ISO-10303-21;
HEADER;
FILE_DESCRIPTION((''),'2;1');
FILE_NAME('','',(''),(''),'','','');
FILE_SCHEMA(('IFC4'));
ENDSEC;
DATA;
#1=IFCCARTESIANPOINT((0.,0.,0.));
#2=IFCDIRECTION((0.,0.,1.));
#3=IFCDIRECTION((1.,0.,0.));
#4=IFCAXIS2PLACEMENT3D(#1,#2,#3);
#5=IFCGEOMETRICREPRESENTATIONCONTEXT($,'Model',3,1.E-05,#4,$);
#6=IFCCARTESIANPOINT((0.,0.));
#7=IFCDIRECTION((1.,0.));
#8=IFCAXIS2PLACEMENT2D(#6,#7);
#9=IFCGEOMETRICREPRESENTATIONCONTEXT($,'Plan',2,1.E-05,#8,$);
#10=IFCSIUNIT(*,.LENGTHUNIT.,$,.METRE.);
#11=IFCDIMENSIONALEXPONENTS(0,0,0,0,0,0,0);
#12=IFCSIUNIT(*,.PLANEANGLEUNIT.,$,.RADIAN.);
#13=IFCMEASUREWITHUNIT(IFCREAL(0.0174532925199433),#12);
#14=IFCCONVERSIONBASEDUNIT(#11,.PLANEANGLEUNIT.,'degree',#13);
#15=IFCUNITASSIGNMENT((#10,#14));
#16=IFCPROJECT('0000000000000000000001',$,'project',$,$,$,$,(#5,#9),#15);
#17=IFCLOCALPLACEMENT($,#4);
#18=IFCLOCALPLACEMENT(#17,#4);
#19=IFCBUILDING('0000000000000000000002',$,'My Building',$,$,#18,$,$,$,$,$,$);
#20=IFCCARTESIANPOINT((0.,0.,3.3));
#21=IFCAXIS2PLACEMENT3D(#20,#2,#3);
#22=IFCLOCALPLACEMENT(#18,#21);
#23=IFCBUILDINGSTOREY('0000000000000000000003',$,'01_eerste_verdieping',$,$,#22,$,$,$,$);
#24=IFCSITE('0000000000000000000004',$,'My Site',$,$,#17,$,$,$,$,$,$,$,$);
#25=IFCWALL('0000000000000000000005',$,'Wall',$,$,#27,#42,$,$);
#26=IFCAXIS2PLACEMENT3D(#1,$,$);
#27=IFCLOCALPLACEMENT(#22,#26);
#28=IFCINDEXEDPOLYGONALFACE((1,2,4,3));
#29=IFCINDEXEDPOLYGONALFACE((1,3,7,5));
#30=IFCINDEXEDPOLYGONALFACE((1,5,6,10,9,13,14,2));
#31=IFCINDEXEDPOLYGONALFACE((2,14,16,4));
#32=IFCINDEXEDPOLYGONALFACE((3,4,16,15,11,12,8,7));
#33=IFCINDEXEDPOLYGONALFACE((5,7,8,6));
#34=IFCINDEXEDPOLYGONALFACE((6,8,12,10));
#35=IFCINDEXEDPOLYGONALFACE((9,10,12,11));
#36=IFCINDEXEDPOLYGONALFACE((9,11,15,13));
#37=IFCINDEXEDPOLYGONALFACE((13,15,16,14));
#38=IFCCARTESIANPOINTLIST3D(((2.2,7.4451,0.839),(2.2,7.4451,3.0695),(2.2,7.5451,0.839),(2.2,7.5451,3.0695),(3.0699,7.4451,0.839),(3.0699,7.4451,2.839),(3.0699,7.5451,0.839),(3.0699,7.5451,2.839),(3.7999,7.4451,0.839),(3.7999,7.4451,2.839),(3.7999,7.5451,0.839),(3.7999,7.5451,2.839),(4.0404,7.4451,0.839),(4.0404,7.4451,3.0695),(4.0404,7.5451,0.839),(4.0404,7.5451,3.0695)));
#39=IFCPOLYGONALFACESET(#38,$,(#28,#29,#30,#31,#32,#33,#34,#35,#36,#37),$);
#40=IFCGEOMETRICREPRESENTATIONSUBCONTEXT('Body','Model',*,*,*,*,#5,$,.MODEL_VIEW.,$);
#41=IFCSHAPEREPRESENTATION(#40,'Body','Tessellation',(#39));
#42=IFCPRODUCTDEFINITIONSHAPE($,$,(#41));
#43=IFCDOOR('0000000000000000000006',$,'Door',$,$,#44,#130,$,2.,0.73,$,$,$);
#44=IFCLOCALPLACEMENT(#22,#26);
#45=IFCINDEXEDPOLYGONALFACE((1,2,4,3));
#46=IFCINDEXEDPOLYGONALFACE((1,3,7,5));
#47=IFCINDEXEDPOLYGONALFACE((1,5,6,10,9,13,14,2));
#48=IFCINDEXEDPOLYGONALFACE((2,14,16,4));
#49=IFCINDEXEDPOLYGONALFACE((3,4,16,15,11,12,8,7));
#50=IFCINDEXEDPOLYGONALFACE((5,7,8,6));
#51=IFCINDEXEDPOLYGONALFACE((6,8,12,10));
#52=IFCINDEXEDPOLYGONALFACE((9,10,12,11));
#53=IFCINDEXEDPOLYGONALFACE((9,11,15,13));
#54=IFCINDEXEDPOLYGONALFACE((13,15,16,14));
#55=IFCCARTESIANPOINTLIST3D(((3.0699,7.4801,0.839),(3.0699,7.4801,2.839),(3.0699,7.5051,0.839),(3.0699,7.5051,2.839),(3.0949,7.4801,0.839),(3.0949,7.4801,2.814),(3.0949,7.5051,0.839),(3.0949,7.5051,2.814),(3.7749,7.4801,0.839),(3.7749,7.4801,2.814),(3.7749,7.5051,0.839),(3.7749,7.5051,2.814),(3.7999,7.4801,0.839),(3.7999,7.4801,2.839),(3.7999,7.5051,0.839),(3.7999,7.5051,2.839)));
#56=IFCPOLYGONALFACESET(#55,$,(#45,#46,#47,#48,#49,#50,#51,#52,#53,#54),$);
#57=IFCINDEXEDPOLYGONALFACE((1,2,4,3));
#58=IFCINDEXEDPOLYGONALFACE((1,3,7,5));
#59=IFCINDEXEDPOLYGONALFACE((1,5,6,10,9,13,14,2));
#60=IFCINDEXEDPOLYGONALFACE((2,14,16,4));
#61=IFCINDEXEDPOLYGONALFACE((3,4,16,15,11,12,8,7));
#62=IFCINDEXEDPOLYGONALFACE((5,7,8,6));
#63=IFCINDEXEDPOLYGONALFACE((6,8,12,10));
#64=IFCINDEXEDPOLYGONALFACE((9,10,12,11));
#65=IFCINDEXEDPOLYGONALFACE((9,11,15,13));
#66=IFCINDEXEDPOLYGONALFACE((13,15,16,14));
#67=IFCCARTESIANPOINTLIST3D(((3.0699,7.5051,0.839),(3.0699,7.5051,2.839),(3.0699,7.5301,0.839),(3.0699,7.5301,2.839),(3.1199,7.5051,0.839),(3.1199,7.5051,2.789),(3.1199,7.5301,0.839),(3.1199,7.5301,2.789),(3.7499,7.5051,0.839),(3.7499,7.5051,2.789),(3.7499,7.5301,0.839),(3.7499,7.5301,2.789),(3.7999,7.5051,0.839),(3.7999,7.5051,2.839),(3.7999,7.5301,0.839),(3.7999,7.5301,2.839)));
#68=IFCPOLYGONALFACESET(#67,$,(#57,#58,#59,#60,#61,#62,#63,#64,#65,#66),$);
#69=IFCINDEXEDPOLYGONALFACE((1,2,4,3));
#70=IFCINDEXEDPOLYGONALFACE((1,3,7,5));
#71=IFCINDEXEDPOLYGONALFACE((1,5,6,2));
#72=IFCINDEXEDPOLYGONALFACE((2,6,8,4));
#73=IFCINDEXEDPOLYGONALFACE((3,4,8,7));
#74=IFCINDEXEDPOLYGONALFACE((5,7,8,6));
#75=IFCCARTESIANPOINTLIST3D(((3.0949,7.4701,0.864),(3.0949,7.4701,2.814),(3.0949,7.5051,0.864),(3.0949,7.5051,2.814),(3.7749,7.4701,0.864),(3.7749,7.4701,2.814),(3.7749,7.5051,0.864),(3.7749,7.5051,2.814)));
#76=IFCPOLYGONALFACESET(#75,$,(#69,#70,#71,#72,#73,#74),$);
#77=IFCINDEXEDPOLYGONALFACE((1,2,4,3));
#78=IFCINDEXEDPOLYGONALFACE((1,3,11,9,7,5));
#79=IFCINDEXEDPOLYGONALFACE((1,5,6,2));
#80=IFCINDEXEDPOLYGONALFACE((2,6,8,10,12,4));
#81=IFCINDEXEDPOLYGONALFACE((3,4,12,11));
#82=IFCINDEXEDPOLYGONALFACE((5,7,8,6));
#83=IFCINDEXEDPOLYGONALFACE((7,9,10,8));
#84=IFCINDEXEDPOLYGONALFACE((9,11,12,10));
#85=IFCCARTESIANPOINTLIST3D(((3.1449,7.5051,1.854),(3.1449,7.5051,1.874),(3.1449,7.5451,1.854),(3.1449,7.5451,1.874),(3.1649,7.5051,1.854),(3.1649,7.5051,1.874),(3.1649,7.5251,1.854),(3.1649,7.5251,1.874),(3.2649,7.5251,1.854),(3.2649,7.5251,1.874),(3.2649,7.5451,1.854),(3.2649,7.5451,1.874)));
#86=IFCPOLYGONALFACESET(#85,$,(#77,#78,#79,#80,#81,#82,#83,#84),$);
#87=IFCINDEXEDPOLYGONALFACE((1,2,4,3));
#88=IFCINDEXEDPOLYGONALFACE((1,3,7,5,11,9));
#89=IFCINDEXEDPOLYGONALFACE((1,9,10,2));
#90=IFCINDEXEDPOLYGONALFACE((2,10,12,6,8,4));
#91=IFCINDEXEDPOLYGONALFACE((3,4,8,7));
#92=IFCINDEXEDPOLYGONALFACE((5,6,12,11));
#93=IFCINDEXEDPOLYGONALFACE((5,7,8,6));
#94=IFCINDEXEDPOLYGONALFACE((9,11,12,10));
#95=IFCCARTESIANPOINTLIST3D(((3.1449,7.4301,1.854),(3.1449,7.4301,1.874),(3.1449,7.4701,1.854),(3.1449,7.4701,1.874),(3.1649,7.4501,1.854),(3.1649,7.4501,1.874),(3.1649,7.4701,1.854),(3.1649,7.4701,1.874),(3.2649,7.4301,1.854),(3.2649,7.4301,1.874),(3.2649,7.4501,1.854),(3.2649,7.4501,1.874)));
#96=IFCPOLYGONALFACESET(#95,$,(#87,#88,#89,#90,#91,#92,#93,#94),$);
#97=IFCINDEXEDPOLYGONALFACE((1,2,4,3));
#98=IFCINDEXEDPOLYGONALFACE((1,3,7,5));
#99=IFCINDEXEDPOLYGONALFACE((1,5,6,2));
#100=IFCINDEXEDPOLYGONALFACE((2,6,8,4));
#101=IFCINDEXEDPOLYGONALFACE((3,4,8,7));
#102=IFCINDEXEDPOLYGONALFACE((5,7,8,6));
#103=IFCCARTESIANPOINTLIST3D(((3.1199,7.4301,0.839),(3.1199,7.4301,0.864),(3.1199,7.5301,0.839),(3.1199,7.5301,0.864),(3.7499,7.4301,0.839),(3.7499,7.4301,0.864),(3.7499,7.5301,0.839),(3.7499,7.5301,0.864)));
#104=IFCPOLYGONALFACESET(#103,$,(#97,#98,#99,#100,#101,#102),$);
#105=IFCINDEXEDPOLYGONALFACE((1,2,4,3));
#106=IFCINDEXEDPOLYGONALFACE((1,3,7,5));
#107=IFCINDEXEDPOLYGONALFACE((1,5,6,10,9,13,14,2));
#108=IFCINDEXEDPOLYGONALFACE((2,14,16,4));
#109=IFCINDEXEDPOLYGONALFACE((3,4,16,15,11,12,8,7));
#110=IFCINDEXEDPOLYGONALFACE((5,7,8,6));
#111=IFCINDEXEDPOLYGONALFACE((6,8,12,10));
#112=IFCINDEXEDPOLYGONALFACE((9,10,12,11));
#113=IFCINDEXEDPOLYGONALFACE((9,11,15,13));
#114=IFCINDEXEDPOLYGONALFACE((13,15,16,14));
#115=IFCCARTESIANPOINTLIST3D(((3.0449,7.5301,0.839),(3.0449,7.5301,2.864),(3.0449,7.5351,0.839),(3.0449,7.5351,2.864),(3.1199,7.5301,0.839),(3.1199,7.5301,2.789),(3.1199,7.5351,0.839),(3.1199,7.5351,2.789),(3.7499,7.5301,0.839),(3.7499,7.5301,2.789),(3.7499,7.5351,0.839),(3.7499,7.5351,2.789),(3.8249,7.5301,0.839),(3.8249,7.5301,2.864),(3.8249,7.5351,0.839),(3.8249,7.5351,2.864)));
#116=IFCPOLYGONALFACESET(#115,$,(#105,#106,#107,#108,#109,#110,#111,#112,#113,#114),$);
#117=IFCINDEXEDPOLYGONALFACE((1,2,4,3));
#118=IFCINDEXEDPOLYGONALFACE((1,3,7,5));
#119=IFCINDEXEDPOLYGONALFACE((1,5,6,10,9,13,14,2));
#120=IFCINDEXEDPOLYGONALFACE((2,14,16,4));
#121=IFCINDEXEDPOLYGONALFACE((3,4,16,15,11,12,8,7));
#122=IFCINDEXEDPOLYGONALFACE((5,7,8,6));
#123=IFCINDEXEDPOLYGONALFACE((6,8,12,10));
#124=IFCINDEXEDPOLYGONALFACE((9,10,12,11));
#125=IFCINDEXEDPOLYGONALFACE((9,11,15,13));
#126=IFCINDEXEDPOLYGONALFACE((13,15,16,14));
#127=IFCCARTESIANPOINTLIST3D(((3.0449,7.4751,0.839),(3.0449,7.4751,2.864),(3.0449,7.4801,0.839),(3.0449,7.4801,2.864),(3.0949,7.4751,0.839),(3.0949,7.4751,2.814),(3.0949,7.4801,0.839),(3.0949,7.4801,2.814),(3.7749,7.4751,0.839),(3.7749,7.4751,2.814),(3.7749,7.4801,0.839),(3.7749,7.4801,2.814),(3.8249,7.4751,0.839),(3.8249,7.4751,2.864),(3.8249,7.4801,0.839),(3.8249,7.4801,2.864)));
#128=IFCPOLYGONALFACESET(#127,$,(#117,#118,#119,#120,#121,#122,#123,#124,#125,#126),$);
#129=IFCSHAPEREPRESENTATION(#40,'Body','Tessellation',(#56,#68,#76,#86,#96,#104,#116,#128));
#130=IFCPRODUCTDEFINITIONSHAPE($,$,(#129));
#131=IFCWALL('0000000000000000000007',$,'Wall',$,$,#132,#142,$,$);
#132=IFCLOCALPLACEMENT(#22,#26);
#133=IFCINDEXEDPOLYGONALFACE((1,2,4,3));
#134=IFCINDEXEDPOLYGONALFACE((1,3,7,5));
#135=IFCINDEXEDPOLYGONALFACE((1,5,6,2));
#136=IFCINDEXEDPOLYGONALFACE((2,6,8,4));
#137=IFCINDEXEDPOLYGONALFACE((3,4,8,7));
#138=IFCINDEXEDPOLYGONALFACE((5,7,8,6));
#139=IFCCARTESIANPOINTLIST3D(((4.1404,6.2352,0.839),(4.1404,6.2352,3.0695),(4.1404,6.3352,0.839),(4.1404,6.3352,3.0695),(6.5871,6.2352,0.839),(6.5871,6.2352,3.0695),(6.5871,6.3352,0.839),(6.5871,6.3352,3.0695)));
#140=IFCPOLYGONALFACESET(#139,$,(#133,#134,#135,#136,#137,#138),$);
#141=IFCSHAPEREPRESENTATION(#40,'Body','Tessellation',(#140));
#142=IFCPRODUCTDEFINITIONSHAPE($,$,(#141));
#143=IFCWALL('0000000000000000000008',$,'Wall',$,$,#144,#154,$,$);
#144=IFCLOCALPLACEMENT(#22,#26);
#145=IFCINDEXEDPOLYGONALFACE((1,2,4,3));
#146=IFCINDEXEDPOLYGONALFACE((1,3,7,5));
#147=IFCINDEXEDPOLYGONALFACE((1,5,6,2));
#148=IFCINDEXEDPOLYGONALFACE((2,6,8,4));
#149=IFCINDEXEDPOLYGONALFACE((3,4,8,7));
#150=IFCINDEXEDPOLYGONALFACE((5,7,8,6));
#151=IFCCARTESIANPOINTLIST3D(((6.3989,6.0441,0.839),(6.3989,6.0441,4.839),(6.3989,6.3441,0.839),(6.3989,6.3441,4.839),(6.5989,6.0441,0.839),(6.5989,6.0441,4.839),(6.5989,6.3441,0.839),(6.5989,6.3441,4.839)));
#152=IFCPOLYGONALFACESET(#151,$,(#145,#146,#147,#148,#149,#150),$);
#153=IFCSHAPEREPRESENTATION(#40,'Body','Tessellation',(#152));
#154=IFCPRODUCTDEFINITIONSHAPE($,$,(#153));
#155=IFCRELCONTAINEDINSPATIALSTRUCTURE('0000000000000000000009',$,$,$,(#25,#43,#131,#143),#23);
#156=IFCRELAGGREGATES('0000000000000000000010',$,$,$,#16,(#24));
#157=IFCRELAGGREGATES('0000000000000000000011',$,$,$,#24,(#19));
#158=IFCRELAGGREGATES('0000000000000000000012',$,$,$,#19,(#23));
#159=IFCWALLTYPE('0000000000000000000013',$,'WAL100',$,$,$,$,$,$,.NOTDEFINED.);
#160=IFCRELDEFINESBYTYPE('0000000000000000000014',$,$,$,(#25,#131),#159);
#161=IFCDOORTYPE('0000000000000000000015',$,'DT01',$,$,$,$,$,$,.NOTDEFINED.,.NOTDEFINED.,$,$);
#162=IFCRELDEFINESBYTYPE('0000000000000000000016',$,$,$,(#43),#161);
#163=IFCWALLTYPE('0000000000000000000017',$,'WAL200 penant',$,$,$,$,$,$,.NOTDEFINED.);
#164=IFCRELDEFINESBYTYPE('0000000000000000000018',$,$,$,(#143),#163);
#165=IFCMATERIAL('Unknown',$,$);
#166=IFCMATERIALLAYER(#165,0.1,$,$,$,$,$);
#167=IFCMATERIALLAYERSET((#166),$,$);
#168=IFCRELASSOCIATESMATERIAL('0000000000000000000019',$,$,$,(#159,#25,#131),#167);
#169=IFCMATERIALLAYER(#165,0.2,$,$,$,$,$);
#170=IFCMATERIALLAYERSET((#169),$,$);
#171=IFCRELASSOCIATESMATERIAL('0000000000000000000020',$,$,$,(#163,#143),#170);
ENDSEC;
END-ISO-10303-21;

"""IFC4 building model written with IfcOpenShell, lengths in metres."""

from ifc_helpers import new_model, entity, si_unit, converted_unit, frame, origin_with_axes, origin_2d_with_axis, place, context, subcontext, project, spatial, line, indexed_curve, outline, extrude, clip, halfspace, shape, source, transform, mapped, material, layer, layer_set, layer_usage, type_object, type_shapes, element, fill, save


model = new_model("IFC4")

# Units and contexts
model_context = context("Model", 3, precision=1e-05, world=origin_with_axes())
plan_context = context("Plan", 2, precision=1e-05, world=origin_2d_with_axis())
body_context_1 = subcontext(model_context, "Body", "Model", "MODEL_VIEW")
body_context_2 = subcontext(plan_context, "Body", "Plan", "PLAN_VIEW")
ifc_project = project(units=[si_unit("LENGTHUNIT", "METRE"), converted_unit("PLANEANGLEUNIT", "degree", entity("IfcReal", 0.0174532925199433), si_unit("PLANEANGLEUNIT", "RADIAN"), dimensions=[0, 0, 0, 0, 0, 0, 0])], contexts=[model_context, plan_context])

# Site, building, storey
site_placement = place(None, origin_with_axes())
site = spatial("IfcSite", under=ifc_project, at=site_placement, Name="My Site")
building_placement = place(site_placement, origin_with_axes())
building = spatial("IfcBuilding", under=site, at=building_placement, Name="My Building")
storey_placement = place(building_placement, frame((0.0, 0.0, 3.3), z_axis=(0.0, 0.0, 1.0), x_axis=(1.0, 0.0, 0.0)))
storey = spatial("IfcBuildingStorey", under=building, at=storey_placement, Name="01_eerste_verdieping")

# Shared definitions
ifc_material_1 = material(Name="Unknown")

# Shared definitions
ifc_layer_1 = layer(ifc_material_1, 0.1)
ifc_layer_set_1 = layer_set([ifc_layer_1])
wall_type_1 = type_object("IfcWallType", Name="WAL100", PredefinedType="NOTDEFINED", material=ifc_layer_set_1)

# Wall, opening, door
ifc_layer_usage_1 = layer_usage(ifc_layer_set_1, "AXIS2", "POSITIVE", 0.0)
wall_1_placement = place(storey_placement, frame((2.2, 7.4451, 0.839), z_axis=(0.0, 0.0, 1.0), x_axis=(1.0, -0.000001, 0.0)))
wall_1 = element("IfcWall", 1, at=wall_1_placement, inside=storey, type_object=wall_type_1, material=ifc_layer_usage_1, Name="Wall", context=body_context_1, shape_type="Clipping", body=[
    clip(extrude(outline(indexed_curve([(0.0, 0.0), (0.0, 0.1), (1.8404, 0.1), (1.8404, 0.0), (0.0, 0.0)], self_intersect=False)), origin_with_axes(), (0.0, 0.0, 1.0), 6.3695), halfspace(frame((0.0, 0.0, 2.2305), z_axis=(0.0, 0.0, 1.0), x_axis=(-1.0, 0.0, 0.0)), False)),
])
shared_shape_1 = source(origin_with_axes(), body_context_1, "Body", "SweptSolid", [
    extrude(outline(indexed_curve([(0.0, 0.0), (0.73, 0.0), (0.73, 2.0), (0.0, 2.0)], segments=[line(1, 2, 3, 4, 1)])), frame((0.0, -0.1, 0.0), z_axis=(0.0, -1.0, 0.0), x_axis=(1.0, 0.0, 0.0)), (0.0, 0.0, -1.0), 0.3),
])
opening_placement = place(wall_1_placement, frame((0.8699, 0.0, 0.0), z_axis=(0.0, 0.0, 1.0), x_axis=(1.0, 0.000001, 0.0)))
opening = element("IfcOpeningElement", 2, at=opening_placement, cuts=wall_1, PredefinedType="OPENING", context=body_context_1, shape_type="MappedRepresentation", body=[
    mapped(shared_shape_1, transform((0.0, 0.0, 0.0), x_axis=(1.0, 0.0, 0.0), y_axis=(0.0, 1.0, 0.0), z_axis=(0.0, 0.0, 1.0), scale=1.0)),
])
door_type = type_object("IfcDoorType", Name="DT01", OperationType="NOTDEFINED", PredefinedType="NOTDEFINED")
shared_shape_2 = source(origin_with_axes(), body_context_1, "Body", "SweptSolid", [
    extrude(outline(indexed_curve([(0.025, 0.0), (0.025, 1.975), (0.705, 1.975), (0.705, 0.0), (0.73, 0.0), (0.73, 2.0), (0.0, 2.0), (0.0, 0.0)], segments=[line(3, 2), line(2, 1), line(1, 8), line(8, 7), line(7, 6), line(6, 5), line(5, 4), line(4, 3)], self_intersect=False)), frame((0.0, 0.025, 0.0), z_axis=(0.0, -1.0, 0.0), x_axis=(1.0, 0.0, 0.0)), (0.0, 0.0, -1.0), 0.025),
    extrude(outline(indexed_curve([(0.0, 0.0), (0.0, 2.0), (0.73, 2.0), (0.73, 0.0), (0.68, 0.0), (0.68, 1.95), (0.05, 1.95), (0.05, 0.0)], segments=[line(1, 2, 3, 4, 5, 6, 7, 8, 1)])), frame((0.0, 0.0, 0.0), z_axis=(0.0, -1.0, 0.0), x_axis=(1.0, 0.0, 0.0)), (0.0, 0.0, -1.0), 0.025),
    extrude(outline(indexed_curve([(0.0, 0.0), (0.68, 0.0), (0.68, 0.035), (0.0, 0.035)], segments=[line(1, 2, 3, 4, 1)])), frame((0.025, 0.025, 0.025), z_axis=(0.0, 0.0, 1.0), x_axis=(1.0, 0.0, 0.0)), (0.0, 0.0, 1.0), 1.95),
    extrude(outline(indexed_curve([(0.0, 0.0), (0.0, -0.04), (-0.12, -0.04), (-0.12, -0.02), (-0.02, -0.02), (-0.02, 0.0)], segments=[line(1, 2, 3, 4, 5, 6, 1)])), frame((0.655, 0.025, 1.015), z_axis=(0.0, 0.0, 1.0), x_axis=(1.0, 0.0, 0.0)), (0.0, 0.0, 1.0), 0.02),
    extrude(outline(indexed_curve([(0.0, 0.0), (0.0, 0.04), (-0.12, 0.04), (-0.12, 0.02), (-0.02, 0.02), (-0.02, 0.0)], segments=[line(1, 2, 3, 4, 5, 6, 1)])), frame((0.655, 0.06, 1.015), z_axis=(0.0, 0.0, 1.0), x_axis=(1.0, 0.0, 0.0)), (0.0, 0.0, 1.0), 0.02),
    extrude(outline(indexed_curve([(0.0, 0.0), (0.63, 0.0), (0.63, 0.1), (0.0, 0.1)], segments=[line(1, 2, 3, 4, 1)])), frame((0.05, 0.0, 0.0), z_axis=(0.0, 0.0, 1.0), x_axis=(1.0, 0.0, 0.0)), (0.0, 0.0, 1.0), 0.025),
    extrude(outline(indexed_curve([(0.0, 0.0), (0.0, 2.025), (0.78, 2.025), (0.78, 0.0), (0.705, 0.0), (0.705, 1.95), (0.075, 1.95), (0.075, 0.0)], segments=[line(1, 2, 3, 4, 5, 6, 7, 8, 1)])), frame((-0.025, -0.005, 0.0), z_axis=(0.0, -1.0, 0.0), x_axis=(1.0, 0.0, 0.0)), (0.0, 0.0, -1.0), 0.005),
    extrude(outline(indexed_curve([(0.0, 0.0), (0.0, 2.025), (0.78, 2.025), (0.78, 0.0), (0.73, 0.0), (0.73, 1.975), (0.05, 1.975), (0.05, 0.0)], segments=[line(1, 2, 3, 4, 5, 6, 7, 8, 1)])), frame((-0.025, 0.05, 0.0), z_axis=(0.0, -1.0, 0.0), x_axis=(1.0, 0.0, 0.0)), (0.0, 0.0, -1.0), 0.005),
])
shared_shape_3 = source(origin_with_axes(), body_context_2, "Body", "Curve2D", [
    entity("IfcIndexedPolyCurve", entity("IfcCartesianPointList2D", [[0.0, 0.0], [0.0, 0.05], [0.025, 0.05], [0.025, 0.025], [0.05, 0.025], [0.05, 0.0]]), [entity("IfcLineIndex", [1, 2, 3, 4, 5, 6, 1])]),
    entity("IfcIndexedPolyCurve", entity("IfcCartesianPointList2D", [[0.73, 0.0], [0.73, 0.05], [0.705, 0.05], [0.705, 0.025], [0.68, 0.025], [0.68, 0.0]]), [entity("IfcLineIndex", [1, 2, 3, 4, 5, 6, 1])]),
    entity("IfcTrimmedCurve", entity("IfcEllipse", entity("IfcAxis2Placement2D", entity("IfcCartesianPoint", [0.06, 0.05]), entity("IfcDirection", [1.0, 0.0])), 0.645, 0.68), [entity("IfcCartesianPoint", [0.705, 0.05])], [entity("IfcCartesianPoint", [0.06, 0.73])], True, "CARTESIAN"),
    entity("IfcIndexedPolyCurve", entity("IfcCartesianPointList2D", [[0.025, 0.05], [0.06, 0.05], [0.06, 0.73], [0.025, 0.73]]), [entity("IfcLineIndex", [1, 2, 3, 4, 1])]),
])
type_shapes(door_type, [shared_shape_2, shared_shape_3])
door_placement = place(opening_placement, frame((0.73, 0.085, 0.0), z_axis=(0.0, 0.0, 1.0), x_axis=(-1.0, 0.0, 0.0)))
door = element("IfcDoor", 3, at=door_placement, inside=storey, type_object=door_type, Name="Door", OverallHeight=2.0, OverallWidth=0.73, shapes=[
    shape(body_context_1, "Body", "MappedRepresentation", [mapped(shared_shape_2, transform((0.0, 0.0, 0.0), x_axis=(1.0, 0.0, 0.0), y_axis=(0.0, 1.0, 0.0), z_axis=(0.0, 0.0, 1.0), scale=1.0))]),
    shape(body_context_2, "Body", "MappedRepresentation", [mapped(shared_shape_3, transform((0.0, 0.0, 0.0), x_axis=(1.0, 0.0, 0.0), y_axis=(0.0, 1.0, 0.0), z_axis=(0.0, 0.0, 1.0), scale=1.0))]),
])
fill(opening, door)

# Walls
ifc_layer_usage_2 = layer_usage(ifc_layer_set_1, "AXIS2", "POSITIVE", 0.0)
wall_2_placement = place(storey_placement, frame((4.1404, 6.2352, 0.839), z_axis=(0.0, 0.0, 1.0), x_axis=(1.0, 0.0, 0.0)))
element("IfcWall", 4, at=wall_2_placement, inside=storey, type_object=wall_type_1, material=ifc_layer_usage_2, Name="Wall", context=body_context_1, shape_type="Clipping", body=[
    clip(extrude(outline(indexed_curve([(0.0, 0.0), (0.0, 0.1), (2.4466, 0.1), (2.4466, 0.0), (0.0, 0.0)], self_intersect=False)), origin_with_axes(), (0.0, 0.0, 1.0), 6.3695), halfspace(frame((0.0, 0.0, 2.2305), z_axis=(0.0, 0.0, 1.0), x_axis=(-1.0, 0.0, 0.0)), False)),
])
ifc_layer_2 = layer(ifc_material_1, 0.2)
ifc_layer_set_2 = layer_set([ifc_layer_2])
ifc_layer_usage_3 = layer_usage(ifc_layer_set_2, "AXIS2", "POSITIVE", 0.0)
wall_type_2 = type_object("IfcWallType", Name="WAL200 penant", PredefinedType="NOTDEFINED", material=ifc_layer_set_2)
wall_3_placement = place(storey_placement, frame((6.5989, 6.0441, 0.839), z_axis=(0.0, 0.0, 1.0), x_axis=(0.0, 1.0, 0.0)))
element("IfcWall", 5, at=wall_3_placement, inside=storey, type_object=wall_type_2, material=ifc_layer_usage_3, Name="Wall", context=body_context_1, shape_type="SweptSolid", body=[
    extrude(outline(indexed_curve([(0.0, 0.0), (0.0, 0.2), (0.3, 0.2), (0.3, 0.0), (0.0, 0.0)], self_intersect=False)), origin_with_axes(), (0.0, 0.0, 1.0), 4.0),
])

save(model, "model.ifc")
